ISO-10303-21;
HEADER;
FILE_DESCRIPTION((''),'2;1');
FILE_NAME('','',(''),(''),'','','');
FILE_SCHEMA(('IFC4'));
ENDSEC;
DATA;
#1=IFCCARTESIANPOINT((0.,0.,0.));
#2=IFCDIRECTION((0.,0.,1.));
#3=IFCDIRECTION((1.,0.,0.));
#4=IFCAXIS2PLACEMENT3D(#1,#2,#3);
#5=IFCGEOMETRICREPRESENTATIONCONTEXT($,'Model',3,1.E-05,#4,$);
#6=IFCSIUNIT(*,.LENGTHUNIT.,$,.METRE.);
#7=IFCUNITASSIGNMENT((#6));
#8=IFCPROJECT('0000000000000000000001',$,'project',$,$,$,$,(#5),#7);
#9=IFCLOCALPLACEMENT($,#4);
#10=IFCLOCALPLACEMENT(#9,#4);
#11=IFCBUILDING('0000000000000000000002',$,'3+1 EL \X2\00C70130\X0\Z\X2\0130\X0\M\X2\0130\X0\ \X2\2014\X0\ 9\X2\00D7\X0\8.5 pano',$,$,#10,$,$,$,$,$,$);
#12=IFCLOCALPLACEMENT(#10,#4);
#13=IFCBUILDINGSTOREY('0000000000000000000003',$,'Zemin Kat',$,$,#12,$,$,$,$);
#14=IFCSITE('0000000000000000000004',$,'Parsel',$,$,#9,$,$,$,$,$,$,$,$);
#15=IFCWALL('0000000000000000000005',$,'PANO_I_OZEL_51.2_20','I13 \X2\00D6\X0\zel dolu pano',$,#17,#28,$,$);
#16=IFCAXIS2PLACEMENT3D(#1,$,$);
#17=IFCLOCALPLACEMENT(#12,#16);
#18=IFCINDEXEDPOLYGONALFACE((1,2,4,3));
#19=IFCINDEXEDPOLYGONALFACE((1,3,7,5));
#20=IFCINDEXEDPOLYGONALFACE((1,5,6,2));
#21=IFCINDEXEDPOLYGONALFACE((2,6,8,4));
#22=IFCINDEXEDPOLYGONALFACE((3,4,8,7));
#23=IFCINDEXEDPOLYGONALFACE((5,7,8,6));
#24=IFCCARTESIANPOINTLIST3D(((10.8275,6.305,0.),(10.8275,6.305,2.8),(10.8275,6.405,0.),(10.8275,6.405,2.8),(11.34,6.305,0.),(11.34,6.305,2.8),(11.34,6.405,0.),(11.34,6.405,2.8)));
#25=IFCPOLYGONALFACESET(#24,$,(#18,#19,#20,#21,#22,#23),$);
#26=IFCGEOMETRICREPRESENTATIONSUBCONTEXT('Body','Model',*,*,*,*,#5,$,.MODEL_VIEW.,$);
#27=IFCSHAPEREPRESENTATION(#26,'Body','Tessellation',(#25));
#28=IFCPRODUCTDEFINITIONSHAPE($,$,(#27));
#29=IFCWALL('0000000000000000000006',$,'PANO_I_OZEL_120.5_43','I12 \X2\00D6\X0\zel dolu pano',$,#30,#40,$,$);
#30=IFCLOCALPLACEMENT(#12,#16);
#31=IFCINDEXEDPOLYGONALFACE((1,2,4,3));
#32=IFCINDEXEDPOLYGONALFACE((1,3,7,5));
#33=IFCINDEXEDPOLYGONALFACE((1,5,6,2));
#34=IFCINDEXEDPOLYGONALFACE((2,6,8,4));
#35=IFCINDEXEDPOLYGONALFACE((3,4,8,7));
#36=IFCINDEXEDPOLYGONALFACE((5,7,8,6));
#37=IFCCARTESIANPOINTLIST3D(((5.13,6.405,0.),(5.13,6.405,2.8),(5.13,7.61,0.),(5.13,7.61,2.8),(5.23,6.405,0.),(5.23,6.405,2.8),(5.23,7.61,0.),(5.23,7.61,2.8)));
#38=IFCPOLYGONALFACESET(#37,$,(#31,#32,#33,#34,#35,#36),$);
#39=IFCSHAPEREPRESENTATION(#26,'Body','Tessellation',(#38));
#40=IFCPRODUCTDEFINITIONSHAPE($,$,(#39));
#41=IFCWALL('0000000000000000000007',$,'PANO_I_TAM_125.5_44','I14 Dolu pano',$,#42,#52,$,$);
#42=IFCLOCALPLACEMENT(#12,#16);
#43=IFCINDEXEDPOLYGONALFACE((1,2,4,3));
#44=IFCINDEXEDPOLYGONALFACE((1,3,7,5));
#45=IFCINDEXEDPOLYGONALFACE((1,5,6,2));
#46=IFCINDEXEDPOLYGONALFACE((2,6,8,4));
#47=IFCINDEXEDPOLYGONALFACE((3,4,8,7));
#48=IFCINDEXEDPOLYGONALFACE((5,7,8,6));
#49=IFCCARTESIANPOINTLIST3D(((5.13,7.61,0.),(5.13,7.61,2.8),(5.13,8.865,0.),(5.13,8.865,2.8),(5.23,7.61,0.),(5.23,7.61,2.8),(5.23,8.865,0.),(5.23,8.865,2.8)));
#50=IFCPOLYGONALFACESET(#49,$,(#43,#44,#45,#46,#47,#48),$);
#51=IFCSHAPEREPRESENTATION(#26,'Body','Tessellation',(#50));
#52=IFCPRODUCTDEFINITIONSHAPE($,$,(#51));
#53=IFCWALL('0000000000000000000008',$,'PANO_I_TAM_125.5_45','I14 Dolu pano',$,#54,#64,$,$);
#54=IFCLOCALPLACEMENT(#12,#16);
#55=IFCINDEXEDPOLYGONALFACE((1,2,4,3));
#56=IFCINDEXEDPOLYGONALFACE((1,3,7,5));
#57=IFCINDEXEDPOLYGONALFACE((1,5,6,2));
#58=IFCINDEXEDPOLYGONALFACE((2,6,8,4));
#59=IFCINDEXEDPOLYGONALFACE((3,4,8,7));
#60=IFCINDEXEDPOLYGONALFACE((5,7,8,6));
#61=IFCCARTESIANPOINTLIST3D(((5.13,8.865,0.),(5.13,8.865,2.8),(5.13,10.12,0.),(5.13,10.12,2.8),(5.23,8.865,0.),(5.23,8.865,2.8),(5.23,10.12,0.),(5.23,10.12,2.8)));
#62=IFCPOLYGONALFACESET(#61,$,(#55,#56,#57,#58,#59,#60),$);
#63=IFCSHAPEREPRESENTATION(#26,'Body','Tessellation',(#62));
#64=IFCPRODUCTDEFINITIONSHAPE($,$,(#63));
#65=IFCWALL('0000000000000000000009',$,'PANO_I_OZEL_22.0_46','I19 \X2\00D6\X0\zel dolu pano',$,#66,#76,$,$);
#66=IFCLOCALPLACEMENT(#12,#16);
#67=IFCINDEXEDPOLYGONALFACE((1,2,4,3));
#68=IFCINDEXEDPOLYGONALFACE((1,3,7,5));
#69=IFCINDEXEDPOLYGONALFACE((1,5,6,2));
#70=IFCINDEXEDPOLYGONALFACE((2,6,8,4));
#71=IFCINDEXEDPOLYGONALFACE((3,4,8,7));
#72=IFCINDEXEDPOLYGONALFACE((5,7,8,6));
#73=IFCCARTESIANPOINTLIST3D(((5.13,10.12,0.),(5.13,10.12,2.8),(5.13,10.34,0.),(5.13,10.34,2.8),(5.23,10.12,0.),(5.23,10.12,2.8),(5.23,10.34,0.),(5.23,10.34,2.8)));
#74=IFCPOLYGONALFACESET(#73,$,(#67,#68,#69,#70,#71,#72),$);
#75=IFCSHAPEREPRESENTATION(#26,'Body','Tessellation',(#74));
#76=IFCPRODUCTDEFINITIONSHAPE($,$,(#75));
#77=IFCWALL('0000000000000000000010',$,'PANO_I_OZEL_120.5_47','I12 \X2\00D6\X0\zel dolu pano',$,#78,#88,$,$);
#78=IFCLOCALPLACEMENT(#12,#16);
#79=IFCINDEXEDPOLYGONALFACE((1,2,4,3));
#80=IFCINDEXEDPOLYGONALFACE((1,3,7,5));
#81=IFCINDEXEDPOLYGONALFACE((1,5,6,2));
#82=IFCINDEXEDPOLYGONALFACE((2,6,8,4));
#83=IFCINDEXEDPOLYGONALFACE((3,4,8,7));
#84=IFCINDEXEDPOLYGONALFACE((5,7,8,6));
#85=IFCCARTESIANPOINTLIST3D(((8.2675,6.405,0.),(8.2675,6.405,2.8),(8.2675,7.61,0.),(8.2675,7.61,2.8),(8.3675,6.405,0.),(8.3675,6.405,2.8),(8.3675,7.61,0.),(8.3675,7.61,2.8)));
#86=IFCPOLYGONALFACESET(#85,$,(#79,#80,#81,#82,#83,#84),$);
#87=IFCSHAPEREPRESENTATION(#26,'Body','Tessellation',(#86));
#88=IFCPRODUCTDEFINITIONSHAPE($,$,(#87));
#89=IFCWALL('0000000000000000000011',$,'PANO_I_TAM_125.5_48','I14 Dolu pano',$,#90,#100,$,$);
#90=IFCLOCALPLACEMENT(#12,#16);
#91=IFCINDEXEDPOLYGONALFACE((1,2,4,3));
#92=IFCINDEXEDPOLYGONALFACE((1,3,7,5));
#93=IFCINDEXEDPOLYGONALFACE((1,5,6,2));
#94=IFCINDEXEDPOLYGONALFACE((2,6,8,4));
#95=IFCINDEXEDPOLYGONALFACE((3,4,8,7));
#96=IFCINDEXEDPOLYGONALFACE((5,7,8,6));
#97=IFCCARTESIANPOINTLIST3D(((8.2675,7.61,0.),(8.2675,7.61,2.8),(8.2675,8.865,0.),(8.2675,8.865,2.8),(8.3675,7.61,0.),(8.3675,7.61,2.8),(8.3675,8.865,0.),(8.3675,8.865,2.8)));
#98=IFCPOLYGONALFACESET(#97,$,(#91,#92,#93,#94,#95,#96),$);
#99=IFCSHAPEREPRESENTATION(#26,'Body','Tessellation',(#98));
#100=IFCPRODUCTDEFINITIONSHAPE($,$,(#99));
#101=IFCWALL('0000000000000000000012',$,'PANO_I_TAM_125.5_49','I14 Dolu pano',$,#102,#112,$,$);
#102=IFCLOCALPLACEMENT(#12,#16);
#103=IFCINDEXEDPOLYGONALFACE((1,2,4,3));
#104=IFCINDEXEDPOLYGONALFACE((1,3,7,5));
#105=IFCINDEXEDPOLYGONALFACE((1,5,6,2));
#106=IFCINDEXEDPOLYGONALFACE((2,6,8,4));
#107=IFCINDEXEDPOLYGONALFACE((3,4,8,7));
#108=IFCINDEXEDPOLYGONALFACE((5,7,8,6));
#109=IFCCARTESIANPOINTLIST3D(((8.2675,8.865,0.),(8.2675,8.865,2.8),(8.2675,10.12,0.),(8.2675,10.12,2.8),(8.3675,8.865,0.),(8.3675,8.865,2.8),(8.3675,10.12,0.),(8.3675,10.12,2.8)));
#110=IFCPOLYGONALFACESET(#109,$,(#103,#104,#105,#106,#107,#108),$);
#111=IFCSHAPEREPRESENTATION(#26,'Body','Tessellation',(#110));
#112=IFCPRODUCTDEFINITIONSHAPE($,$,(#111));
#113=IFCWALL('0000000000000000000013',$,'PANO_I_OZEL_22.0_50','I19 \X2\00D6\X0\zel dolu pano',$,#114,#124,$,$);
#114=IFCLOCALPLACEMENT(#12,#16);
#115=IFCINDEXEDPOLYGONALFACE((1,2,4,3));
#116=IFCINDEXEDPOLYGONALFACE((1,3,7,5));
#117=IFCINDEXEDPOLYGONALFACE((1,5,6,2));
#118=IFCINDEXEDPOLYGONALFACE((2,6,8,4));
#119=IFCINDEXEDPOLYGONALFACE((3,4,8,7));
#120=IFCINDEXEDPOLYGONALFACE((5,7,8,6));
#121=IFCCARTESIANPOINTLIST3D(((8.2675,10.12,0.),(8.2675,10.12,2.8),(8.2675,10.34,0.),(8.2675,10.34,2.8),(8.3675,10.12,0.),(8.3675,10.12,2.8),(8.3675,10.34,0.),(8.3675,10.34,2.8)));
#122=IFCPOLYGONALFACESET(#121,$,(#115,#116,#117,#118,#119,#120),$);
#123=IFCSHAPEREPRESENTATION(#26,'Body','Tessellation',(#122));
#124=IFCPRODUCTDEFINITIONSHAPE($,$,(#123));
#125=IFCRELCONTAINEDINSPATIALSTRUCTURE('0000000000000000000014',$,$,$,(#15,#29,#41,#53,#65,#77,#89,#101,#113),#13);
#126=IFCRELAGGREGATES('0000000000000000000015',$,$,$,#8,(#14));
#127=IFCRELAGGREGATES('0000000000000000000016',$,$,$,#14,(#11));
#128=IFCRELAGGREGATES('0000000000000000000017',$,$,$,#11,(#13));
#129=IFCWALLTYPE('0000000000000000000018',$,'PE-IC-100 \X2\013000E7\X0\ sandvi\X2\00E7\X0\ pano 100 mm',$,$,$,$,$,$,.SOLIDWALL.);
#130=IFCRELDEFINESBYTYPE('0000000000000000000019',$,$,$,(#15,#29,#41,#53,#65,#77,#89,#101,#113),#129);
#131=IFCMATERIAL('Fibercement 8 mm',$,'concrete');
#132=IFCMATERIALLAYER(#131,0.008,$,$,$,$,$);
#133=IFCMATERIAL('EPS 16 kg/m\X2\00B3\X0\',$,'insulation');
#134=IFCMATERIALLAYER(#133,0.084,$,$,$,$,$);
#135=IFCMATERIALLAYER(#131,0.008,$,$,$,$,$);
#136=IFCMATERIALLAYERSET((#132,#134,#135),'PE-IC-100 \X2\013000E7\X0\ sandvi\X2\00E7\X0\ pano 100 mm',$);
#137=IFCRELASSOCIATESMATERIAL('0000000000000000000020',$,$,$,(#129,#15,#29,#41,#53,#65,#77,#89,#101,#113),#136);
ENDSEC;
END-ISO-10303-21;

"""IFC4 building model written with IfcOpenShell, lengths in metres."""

from ifc_helpers import new_model, si_unit, frame, origin_with_axes, place, context, subcontext, project, spatial, line, indexed_curve, outline, extrude, material, layer, layer_set, layer_usage, type_object, element, save


model = new_model("IFC4")

# Units and contexts
model_context = context("Model", 3, precision=1e-05, world=origin_with_axes())
body_context = subcontext(model_context, "Body", "Model", "MODEL_VIEW")
ifc_project = project(units=[si_unit("LENGTHUNIT", "METRE")], contexts=[model_context])

# Site, building, storey
site_placement = place(None, origin_with_axes())
site = spatial("IfcSite", under=ifc_project, at=site_placement, Name="Parsel")
building_placement = place(site_placement, origin_with_axes())
building = spatial("IfcBuilding", under=site, at=building_placement, Name="3+1 EL ÇİZİMİ — 9×8.5 pano")
storey_placement = place(building_placement, origin_with_axes())
storey = spatial("IfcBuildingStorey", under=building, at=storey_placement, Name="Zemin Kat")

# Shared definitions
ifc_material_1 = material(Name="Fibercement 8 mm", Category="concrete")
ifc_material_2 = material(Name="EPS 16 kg/m³", Category="insulation")

# Shared definitions
ifc_layer_1 = layer(ifc_material_1, 0.008)
ifc_layer_2 = layer(ifc_material_2, 0.084)
ifc_layer_3 = layer(ifc_material_1, 0.008)
ifc_layer_set_1 = layer_set([ifc_layer_1, ifc_layer_2, ifc_layer_3], Name="PE-IC-100 İç sandviç pano 100 mm")
wall_type_1 = type_object("IfcWallType", Name="PE-IC-100 İç sandviç pano 100 mm", PredefinedType="SOLIDWALL", material=ifc_layer_set_1)

# Walls
ifc_layer_usage_1 = layer_usage(ifc_layer_set_1, "AXIS2", "POSITIVE", 0.0)
wall_1_placement = place(storey_placement, frame((10.8275, 6.305, 0.0), z_axis=(0.0, 0.0, 1.0), x_axis=(1.0, 0.0, 0.0)))
element("IfcWall", 1, at=wall_1_placement, inside=storey, type_object=wall_type_1, material=ifc_layer_usage_1, Name="PANO_I_OZEL_51.2_20", Description="I13 Özel dolu pano", context=body_context, shape_type="SweptSolid", body=[
    extrude(outline(indexed_curve([(0.0, 0.0), (0.5125, 0.0), (0.5125, 0.1), (0.0, 0.1)], segments=[line(1, 2, 3, 4, 1)])), origin_with_axes(), (0.0, 0.0, 1.0), 2.8),
])
ifc_layer_usage_2 = layer_usage(ifc_layer_set_1, "AXIS2", "POSITIVE", 0.0)
wall_2_placement = place(storey_placement, frame((5.23, 6.405, 0.0), z_axis=(0.0, 0.0, 1.0), x_axis=(0.0, 1.0, 0.0)))
element("IfcWall", 2, at=wall_2_placement, inside=storey, type_object=wall_type_1, material=ifc_layer_usage_2, Name="PANO_I_OZEL_120.5_43", Description="I12 Özel dolu pano", context=body_context, shape_type="SweptSolid", body=[
    extrude(outline(indexed_curve([(0.0, 0.0), (1.205, 0.0), (1.205, 0.1), (0.0, 0.1)], segments=[line(1, 2, 3, 4, 1)])), origin_with_axes(), (0.0, 0.0, 1.0), 2.8),
])
ifc_layer_usage_3 = layer_usage(ifc_layer_set_1, "AXIS2", "POSITIVE", 0.0)
wall_3_placement = place(storey_placement, frame((5.23, 7.61, 0.0), z_axis=(0.0, 0.0, 1.0), x_axis=(0.0, 1.0, 0.0)))
element("IfcWall", 3, at=wall_3_placement, inside=storey, type_object=wall_type_1, material=ifc_layer_usage_3, Name="PANO_I_TAM_125.5_44", Description="I14 Dolu pano", context=body_context, shape_type="SweptSolid", body=[
    extrude(outline(indexed_curve([(0.0, 0.0), (1.255, 0.0), (1.255, 0.1), (0.0, 0.1)], segments=[line(1, 2, 3, 4, 1)])), origin_with_axes(), (0.0, 0.0, 1.0), 2.8),
])
ifc_layer_usage_4 = layer_usage(ifc_layer_set_1, "AXIS2", "POSITIVE", 0.0)
wall_4_placement = place(storey_placement, frame((5.23, 8.865, 0.0), z_axis=(0.0, 0.0, 1.0), x_axis=(0.0, 1.0, 0.0)))
element("IfcWall", 4, at=wall_4_placement, inside=storey, type_object=wall_type_1, material=ifc_layer_usage_4, Name="PANO_I_TAM_125.5_45", Description="I14 Dolu pano", context=body_context, shape_type="SweptSolid", body=[
    extrude(outline(indexed_curve([(0.0, 0.0), (1.255, 0.0), (1.255, 0.1), (0.0, 0.1)], segments=[line(1, 2, 3, 4, 1)])), origin_with_axes(), (0.0, 0.0, 1.0), 2.8),
])
ifc_layer_usage_5 = layer_usage(ifc_layer_set_1, "AXIS2", "POSITIVE", 0.0)
wall_5_placement = place(storey_placement, frame((5.23, 10.12, 0.0), z_axis=(0.0, 0.0, 1.0), x_axis=(0.0, 1.0, 0.0)))
element("IfcWall", 5, at=wall_5_placement, inside=storey, type_object=wall_type_1, material=ifc_layer_usage_5, Name="PANO_I_OZEL_22.0_46", Description="I19 Özel dolu pano", context=body_context, shape_type="SweptSolid", body=[
    extrude(outline(indexed_curve([(0.0, 0.0), (0.22, 0.0), (0.22, 0.1), (0.0, 0.1)], segments=[line(1, 2, 3, 4, 1)])), origin_with_axes(), (0.0, 0.0, 1.0), 2.8),
])
ifc_layer_usage_6 = layer_usage(ifc_layer_set_1, "AXIS2", "POSITIVE", 0.0)
wall_6_placement = place(storey_placement, frame((8.3675, 6.405, 0.0), z_axis=(0.0, 0.0, 1.0), x_axis=(0.0, 1.0, 0.0)))
element("IfcWall", 6, at=wall_6_placement, inside=storey, type_object=wall_type_1, material=ifc_layer_usage_6, Name="PANO_I_OZEL_120.5_47", Description="I12 Özel dolu pano", context=body_context, shape_type="SweptSolid", body=[
    extrude(outline(indexed_curve([(0.0, 0.0), (1.205, 0.0), (1.205, 0.1), (0.0, 0.1)], segments=[line(1, 2, 3, 4, 1)])), origin_with_axes(), (0.0, 0.0, 1.0), 2.8),
])
ifc_layer_usage_7 = layer_usage(ifc_layer_set_1, "AXIS2", "POSITIVE", 0.0)
wall_7_placement = place(storey_placement, frame((8.3675, 7.61, 0.0), z_axis=(0.0, 0.0, 1.0), x_axis=(0.0, 1.0, 0.0)))
element("IfcWall", 7, at=wall_7_placement, inside=storey, type_object=wall_type_1, material=ifc_layer_usage_7, Name="PANO_I_TAM_125.5_48", Description="I14 Dolu pano", context=body_context, shape_type="SweptSolid", body=[
    extrude(outline(indexed_curve([(0.0, 0.0), (1.255, 0.0), (1.255, 0.1), (0.0, 0.1)], segments=[line(1, 2, 3, 4, 1)])), origin_with_axes(), (0.0, 0.0, 1.0), 2.8),
])
ifc_layer_usage_8 = layer_usage(ifc_layer_set_1, "AXIS2", "POSITIVE", 0.0)
wall_8_placement = place(storey_placement, frame((8.3675, 8.865, 0.0), z_axis=(0.0, 0.0, 1.0), x_axis=(0.0, 1.0, 0.0)))
element("IfcWall", 8, at=wall_8_placement, inside=storey, type_object=wall_type_1, material=ifc_layer_usage_8, Name="PANO_I_TAM_125.5_49", Description="I14 Dolu pano", context=body_context, shape_type="SweptSolid", body=[
    extrude(outline(indexed_curve([(0.0, 0.0), (1.255, 0.0), (1.255, 0.1), (0.0, 0.1)], segments=[line(1, 2, 3, 4, 1)])), origin_with_axes(), (0.0, 0.0, 1.0), 2.8),
])
ifc_layer_usage_9 = layer_usage(ifc_layer_set_1, "AXIS2", "POSITIVE", 0.0)
wall_9_placement = place(storey_placement, frame((8.3675, 10.12, 0.0), z_axis=(0.0, 0.0, 1.0), x_axis=(0.0, 1.0, 0.0)))
element("IfcWall", 9, at=wall_9_placement, inside=storey, type_object=wall_type_1, material=ifc_layer_usage_9, Name="PANO_I_OZEL_22.0_50", Description="I19 Özel dolu pano", context=body_context, shape_type="SweptSolid", body=[
    extrude(outline(indexed_curve([(0.0, 0.0), (0.22, 0.0), (0.22, 0.1), (0.0, 0.1)], segments=[line(1, 2, 3, 4, 1)])), origin_with_axes(), (0.0, 0.0, 1.0), 2.8),
])

save(model, "model.ifc")
